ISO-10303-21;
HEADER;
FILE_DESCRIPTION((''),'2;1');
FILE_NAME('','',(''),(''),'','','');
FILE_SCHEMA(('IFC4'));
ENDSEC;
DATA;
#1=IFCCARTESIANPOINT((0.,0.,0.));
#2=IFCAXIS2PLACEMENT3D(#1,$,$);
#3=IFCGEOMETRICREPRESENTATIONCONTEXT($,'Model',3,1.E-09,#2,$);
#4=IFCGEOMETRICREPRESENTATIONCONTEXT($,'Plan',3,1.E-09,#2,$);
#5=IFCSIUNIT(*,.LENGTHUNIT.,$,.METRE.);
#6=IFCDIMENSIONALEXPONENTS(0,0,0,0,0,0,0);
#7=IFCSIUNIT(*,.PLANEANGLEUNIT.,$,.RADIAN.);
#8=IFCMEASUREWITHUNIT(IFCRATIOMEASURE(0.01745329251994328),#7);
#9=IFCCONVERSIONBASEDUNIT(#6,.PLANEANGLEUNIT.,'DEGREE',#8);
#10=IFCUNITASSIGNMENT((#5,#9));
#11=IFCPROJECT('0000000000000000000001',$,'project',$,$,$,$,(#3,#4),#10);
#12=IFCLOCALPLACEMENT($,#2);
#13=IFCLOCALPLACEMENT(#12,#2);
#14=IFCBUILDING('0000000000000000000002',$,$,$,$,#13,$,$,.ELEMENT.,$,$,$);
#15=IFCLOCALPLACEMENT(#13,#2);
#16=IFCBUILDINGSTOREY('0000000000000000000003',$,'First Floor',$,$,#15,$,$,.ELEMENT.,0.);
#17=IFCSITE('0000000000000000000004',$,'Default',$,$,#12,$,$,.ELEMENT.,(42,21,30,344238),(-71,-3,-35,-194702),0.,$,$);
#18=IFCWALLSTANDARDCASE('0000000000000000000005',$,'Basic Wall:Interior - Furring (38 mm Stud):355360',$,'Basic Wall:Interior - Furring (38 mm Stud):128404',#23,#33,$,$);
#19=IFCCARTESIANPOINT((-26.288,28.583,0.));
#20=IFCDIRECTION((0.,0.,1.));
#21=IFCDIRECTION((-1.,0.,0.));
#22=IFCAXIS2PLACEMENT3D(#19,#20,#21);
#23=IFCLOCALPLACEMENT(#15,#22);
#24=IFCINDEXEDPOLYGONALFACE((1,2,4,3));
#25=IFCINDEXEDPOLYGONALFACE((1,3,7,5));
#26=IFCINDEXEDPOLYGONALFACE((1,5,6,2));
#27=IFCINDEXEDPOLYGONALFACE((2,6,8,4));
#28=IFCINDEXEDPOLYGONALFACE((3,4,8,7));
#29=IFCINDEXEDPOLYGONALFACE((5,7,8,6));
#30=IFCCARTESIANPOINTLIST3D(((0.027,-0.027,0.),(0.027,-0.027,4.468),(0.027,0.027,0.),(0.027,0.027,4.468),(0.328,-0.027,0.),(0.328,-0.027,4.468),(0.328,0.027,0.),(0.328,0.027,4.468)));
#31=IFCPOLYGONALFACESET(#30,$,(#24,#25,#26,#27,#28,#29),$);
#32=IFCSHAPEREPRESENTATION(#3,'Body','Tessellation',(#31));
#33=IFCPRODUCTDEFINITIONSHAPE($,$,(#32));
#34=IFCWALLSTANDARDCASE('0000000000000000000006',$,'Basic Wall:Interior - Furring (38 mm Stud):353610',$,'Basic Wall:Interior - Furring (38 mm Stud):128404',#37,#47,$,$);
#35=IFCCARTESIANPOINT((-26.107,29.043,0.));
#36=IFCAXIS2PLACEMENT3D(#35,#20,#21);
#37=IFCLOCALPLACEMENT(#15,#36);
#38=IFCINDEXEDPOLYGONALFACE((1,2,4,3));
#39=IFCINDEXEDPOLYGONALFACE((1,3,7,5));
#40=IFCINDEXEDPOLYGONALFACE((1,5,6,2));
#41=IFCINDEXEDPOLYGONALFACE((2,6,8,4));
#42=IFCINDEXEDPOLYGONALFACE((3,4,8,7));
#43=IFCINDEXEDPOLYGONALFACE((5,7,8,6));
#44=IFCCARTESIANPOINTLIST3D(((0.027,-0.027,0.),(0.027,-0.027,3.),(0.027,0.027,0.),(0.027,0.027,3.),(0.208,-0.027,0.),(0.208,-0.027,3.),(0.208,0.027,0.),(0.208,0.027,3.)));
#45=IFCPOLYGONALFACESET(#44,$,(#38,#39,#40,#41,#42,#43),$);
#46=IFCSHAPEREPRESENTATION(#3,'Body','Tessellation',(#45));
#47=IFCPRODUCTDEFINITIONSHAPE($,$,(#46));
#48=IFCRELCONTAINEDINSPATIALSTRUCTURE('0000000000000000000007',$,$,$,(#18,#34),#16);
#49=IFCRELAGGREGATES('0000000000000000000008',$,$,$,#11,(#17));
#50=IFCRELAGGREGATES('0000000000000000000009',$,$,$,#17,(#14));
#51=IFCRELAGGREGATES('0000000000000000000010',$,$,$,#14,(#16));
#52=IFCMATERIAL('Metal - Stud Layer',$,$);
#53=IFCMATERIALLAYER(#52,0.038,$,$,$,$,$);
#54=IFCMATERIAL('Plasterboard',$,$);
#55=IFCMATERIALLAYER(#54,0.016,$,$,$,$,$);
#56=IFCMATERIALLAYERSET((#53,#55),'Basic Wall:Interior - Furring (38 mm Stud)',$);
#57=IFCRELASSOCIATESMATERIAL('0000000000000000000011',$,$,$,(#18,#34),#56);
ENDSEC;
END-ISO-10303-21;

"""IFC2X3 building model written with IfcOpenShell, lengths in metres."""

from ifc_helpers import new_model, entity, si_unit, converted_unit, frame, frame_2d, origin, place, context, project, spatial, rectangle, extrude, material, layer, layer_set, layer_usage, element, save


model = new_model("IFC2X3")

# Units and contexts
model_context = context("Model", 3, precision=1e-09, world=origin())
plan_context = context("Plan", 3, precision=1e-09, world=origin())
ifc_project = project(units=[si_unit("LENGTHUNIT", "METRE"), converted_unit("PLANEANGLEUNIT", "DEGREE", entity("IfcRatioMeasure", 0.01745329251994328), si_unit("PLANEANGLEUNIT", "RADIAN"), dimensions=[0, 0, 0, 0, 0, 0, 0])], contexts=[model_context, plan_context])

# Site, building, storey
site_placement = place(None, origin())
site = spatial("IfcSite", under=ifc_project, at=site_placement, Name="Default", CompositionType="ELEMENT", RefLatitude=(42, 21, 30, 344238), RefLongitude=(-71, -3, -35, -194702), RefElevation=0.0)
building_placement = place(site_placement, origin())
building = spatial("IfcBuilding", under=site, at=building_placement, CompositionType="ELEMENT")
storey_placement = place(building_placement, origin())
storey = spatial("IfcBuildingStorey", under=building, at=storey_placement, Name="First Floor", CompositionType="ELEMENT", Elevation=0.0)

# Shared definitions
ifc_material_1 = material(Name="Plasterboard")
ifc_layer_1 = layer(ifc_material_1, 0.016)
ifc_material_2 = material(Name="Metal - Stud Layer")

# Wall
ifc_layer_2 = layer(ifc_material_2, 0.038)
ifc_layer_set_1 = layer_set([ifc_layer_2, ifc_layer_1], Name="Basic Wall:Interior - Furring (38 mm Stud)")
ifc_layer_usage_1 = layer_usage(ifc_layer_set_1, "AXIS2", "NEGATIVE", 0.027)
wall_1_placement = place(storey_placement, frame((-26.288, 28.583, 0.0), z_axis=(0.0, 0.0, 1.0), x_axis=(-1.0, 0.0, 0.0)))
element("IfcWallStandardCase", 1, at=wall_1_placement, inside=storey, material=ifc_layer_usage_1, Name="Basic Wall:Interior - Furring (38 mm Stud):355360", ObjectType="Basic Wall:Interior - Furring (38 mm Stud):128404", context=model_context, shape_type="SweptSolid", body=[
    extrude(rectangle(XDim=0.301, YDim=0.054, at=frame_2d((0.1775, 0.0), x_axis=(-1.0, 0.0))), origin(), (0.0, 0.0, 1.0), 4.468),
])

# Wall
wall_2_placement = place(storey_placement, frame((-26.107, 29.043, 0.0), z_axis=(0.0, 0.0, 1.0), x_axis=(-1.0, 0.0, 0.0)))
element("IfcWallStandardCase", 2, at=wall_2_placement, inside=storey, material=ifc_layer_usage_1, Name="Basic Wall:Interior - Furring (38 mm Stud):353610", ObjectType="Basic Wall:Interior - Furring (38 mm Stud):128404", context=model_context, shape_type="SweptSolid", body=[
    extrude(rectangle(XDim=0.181, YDim=0.054, at=frame_2d((0.1175, 0.0), x_axis=(-1.0, 0.0))), origin(), (0.0, 0.0, 1.0), 3.0),
])

save(model, "model.ifc")
